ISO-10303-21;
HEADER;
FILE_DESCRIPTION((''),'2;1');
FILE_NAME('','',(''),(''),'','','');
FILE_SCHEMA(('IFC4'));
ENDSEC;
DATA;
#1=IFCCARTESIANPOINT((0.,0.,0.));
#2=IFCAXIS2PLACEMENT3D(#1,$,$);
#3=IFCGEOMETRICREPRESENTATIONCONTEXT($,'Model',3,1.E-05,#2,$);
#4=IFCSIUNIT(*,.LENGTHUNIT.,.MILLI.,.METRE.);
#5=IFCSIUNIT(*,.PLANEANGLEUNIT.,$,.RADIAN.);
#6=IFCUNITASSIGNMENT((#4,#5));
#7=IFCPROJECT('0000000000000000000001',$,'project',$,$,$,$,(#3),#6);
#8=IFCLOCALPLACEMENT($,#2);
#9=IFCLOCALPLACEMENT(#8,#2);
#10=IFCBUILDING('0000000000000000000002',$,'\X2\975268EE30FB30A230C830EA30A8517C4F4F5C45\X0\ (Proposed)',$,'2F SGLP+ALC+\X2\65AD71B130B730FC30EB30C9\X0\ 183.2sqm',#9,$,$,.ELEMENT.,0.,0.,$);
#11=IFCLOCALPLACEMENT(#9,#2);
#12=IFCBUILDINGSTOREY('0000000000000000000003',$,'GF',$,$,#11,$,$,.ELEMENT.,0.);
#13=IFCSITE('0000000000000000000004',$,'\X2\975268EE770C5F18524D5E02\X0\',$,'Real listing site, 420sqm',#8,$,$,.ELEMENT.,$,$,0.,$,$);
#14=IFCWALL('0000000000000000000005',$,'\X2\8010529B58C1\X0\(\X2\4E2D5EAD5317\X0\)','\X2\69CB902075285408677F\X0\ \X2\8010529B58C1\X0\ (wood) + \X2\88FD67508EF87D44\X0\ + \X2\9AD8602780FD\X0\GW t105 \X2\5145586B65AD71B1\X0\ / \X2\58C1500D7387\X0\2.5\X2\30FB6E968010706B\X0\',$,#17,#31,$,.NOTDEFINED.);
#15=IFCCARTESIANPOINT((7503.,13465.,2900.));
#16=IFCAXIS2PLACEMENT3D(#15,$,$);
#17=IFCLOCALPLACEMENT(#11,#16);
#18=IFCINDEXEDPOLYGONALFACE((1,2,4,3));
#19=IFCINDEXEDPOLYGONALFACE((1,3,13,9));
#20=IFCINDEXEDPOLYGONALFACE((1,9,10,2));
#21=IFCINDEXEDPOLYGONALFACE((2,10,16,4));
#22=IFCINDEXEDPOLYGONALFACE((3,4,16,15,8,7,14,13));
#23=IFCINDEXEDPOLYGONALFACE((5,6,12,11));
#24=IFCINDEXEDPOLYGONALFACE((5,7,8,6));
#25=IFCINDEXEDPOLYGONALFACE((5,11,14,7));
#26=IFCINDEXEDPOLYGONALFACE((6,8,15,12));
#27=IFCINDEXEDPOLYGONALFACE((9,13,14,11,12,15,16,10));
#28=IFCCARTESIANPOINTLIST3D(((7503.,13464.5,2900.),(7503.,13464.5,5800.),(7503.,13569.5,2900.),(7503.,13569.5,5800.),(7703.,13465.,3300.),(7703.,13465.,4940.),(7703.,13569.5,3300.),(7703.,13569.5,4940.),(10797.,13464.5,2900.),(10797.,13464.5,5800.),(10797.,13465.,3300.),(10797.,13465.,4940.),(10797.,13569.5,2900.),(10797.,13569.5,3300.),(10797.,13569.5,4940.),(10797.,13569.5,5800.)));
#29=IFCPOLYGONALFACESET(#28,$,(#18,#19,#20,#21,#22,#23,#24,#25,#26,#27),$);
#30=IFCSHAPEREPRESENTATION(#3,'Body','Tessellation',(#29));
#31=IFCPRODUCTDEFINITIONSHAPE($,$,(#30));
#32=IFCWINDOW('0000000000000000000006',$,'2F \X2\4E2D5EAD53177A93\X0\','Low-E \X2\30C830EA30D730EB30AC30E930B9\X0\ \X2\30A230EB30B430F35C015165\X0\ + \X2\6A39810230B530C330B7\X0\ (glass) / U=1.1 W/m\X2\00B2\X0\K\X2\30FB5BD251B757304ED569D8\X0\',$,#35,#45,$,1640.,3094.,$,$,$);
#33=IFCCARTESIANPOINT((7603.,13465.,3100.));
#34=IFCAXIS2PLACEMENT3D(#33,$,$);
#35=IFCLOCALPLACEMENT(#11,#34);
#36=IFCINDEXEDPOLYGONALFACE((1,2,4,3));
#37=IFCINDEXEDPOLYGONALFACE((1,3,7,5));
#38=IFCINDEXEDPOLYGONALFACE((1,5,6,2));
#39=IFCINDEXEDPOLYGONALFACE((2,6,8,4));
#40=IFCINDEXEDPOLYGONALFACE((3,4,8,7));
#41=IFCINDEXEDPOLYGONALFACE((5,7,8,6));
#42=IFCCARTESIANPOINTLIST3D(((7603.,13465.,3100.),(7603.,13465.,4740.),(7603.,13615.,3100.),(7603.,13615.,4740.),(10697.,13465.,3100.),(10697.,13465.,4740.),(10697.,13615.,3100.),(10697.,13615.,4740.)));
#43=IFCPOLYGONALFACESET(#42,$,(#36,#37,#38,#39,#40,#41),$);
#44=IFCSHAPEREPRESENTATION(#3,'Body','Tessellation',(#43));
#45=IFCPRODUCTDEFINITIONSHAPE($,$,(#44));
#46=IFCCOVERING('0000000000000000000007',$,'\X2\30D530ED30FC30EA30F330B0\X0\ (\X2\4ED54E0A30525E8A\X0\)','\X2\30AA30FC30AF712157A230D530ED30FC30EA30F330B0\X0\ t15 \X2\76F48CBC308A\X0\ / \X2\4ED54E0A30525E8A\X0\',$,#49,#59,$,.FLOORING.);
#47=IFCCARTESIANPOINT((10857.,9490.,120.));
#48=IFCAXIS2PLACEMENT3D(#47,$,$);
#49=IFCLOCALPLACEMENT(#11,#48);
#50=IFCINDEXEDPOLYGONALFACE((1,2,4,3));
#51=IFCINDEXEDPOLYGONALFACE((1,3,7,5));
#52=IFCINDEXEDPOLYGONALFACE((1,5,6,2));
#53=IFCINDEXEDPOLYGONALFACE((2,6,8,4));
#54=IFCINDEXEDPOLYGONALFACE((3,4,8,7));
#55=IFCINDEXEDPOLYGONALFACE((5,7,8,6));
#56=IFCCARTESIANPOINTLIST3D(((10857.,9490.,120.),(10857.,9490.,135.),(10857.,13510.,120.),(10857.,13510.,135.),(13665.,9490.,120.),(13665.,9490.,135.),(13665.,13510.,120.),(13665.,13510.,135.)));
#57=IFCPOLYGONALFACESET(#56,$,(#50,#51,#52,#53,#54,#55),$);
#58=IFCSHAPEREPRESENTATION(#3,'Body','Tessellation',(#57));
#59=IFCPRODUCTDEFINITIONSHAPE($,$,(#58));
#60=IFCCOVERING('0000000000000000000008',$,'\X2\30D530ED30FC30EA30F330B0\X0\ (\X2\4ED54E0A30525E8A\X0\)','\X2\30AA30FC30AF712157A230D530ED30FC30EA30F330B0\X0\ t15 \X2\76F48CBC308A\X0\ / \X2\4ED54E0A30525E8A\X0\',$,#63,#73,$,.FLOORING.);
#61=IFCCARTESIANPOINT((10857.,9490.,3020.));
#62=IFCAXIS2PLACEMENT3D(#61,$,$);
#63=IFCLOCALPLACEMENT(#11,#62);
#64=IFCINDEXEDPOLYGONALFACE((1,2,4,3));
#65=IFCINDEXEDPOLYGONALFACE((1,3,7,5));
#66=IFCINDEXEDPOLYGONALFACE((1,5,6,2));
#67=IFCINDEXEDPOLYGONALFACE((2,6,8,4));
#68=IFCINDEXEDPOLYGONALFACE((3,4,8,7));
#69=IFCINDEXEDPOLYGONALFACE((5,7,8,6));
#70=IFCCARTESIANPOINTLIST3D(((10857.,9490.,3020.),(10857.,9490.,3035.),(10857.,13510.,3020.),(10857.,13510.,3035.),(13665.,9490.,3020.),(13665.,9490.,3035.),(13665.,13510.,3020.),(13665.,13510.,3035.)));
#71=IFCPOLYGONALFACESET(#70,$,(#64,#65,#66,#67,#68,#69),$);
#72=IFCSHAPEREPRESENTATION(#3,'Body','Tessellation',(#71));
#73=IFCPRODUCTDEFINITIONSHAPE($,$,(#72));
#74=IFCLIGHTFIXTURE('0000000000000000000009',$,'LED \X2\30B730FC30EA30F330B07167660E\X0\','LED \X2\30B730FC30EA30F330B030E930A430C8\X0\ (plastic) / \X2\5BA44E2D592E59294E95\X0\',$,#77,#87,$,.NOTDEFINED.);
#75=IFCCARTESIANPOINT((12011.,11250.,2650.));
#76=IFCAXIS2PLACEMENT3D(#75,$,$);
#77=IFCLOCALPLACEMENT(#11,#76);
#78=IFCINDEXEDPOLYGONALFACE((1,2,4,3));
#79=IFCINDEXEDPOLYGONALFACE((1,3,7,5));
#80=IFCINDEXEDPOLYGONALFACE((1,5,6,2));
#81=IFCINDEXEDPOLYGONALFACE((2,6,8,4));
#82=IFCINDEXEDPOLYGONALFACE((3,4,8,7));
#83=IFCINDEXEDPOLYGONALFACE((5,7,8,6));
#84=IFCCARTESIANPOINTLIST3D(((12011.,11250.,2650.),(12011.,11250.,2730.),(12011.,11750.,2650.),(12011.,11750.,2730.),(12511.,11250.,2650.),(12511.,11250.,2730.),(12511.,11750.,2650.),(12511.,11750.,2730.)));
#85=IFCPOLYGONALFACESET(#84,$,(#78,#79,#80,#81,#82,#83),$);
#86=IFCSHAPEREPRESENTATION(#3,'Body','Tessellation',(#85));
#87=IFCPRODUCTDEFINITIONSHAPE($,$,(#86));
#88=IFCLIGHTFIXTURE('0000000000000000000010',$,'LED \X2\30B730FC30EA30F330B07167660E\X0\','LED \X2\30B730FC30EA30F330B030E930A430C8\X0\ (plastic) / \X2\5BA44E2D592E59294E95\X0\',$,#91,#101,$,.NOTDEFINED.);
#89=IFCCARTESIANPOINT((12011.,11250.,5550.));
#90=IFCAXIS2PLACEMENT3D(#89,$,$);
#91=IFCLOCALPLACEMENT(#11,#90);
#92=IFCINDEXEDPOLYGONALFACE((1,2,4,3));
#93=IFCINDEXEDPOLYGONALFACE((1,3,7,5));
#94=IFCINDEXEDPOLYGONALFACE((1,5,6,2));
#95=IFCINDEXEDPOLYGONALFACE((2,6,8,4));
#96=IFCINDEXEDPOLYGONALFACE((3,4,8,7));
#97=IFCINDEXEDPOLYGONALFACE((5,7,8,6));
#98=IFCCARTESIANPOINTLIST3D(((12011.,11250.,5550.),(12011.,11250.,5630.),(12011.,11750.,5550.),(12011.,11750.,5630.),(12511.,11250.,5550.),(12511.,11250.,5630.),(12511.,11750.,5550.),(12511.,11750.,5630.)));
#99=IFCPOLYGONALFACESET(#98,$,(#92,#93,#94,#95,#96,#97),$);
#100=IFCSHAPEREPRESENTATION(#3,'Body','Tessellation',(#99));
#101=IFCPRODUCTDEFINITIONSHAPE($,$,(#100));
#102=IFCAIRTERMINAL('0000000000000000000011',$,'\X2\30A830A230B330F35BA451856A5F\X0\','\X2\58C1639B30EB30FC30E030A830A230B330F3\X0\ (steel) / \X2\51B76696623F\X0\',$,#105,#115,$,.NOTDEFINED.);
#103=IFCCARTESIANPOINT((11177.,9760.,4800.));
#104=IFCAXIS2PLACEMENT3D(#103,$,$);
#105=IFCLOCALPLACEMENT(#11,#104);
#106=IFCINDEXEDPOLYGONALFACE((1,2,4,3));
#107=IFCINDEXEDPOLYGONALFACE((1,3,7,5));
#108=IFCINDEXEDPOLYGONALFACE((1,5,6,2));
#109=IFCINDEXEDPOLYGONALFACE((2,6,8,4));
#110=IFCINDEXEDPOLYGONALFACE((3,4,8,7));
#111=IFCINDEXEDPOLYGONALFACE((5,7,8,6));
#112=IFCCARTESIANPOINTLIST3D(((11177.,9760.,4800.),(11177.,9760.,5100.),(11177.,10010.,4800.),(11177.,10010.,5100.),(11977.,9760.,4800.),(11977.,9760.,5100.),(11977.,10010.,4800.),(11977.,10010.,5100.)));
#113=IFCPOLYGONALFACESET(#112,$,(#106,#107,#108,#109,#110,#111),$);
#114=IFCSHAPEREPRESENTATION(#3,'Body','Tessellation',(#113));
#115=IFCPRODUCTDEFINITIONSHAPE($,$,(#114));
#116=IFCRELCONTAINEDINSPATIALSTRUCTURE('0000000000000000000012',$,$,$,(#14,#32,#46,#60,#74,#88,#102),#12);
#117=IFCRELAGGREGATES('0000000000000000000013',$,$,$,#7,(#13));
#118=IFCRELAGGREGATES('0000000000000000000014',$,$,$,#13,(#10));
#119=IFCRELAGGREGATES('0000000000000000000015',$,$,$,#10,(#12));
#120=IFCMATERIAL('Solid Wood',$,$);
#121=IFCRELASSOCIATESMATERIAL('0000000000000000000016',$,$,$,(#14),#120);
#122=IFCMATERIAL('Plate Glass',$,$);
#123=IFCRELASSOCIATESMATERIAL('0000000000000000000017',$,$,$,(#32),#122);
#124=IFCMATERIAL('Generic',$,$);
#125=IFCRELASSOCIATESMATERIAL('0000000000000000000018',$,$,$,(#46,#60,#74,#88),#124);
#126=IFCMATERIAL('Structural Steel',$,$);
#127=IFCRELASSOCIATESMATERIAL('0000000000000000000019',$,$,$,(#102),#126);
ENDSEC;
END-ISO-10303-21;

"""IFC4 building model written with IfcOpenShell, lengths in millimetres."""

from ifc_helpers import new_model, si_unit, frame, frame_2d, origin, place, context, project, spatial, rectangle, extrude, material, element, fill, save


model = new_model("IFC4")

# Units and contexts
model_context = context("Model", 3, precision=1e-05, world=origin())
ifc_project = project(units=[si_unit("LENGTHUNIT", "METRE", prefix="MILLI"), si_unit("PLANEANGLEUNIT", "RADIAN")], contexts=[model_context])

# Site, building, storey
site_placement = place(None, origin())
site = spatial("IfcSite", under=ifc_project, at=site_placement, Name="青森県弘前市", ObjectType="Real listing site, 420sqm", CompositionType="ELEMENT", RefElevation=0.0)
building_placement = place(site_placement, origin())
building = spatial("IfcBuilding", under=site, at=building_placement, Name="青森・アトリエ兼住居 (Proposed)", ObjectType="2F SGLP+ALC+断熱シールド 183.2sqm", CompositionType="ELEMENT", ElevationOfRefHeight=0.0, ElevationOfTerrain=0.0)
storey_placement = place(building_placement, origin())
storey = spatial("IfcBuildingStorey", under=building, at=storey_placement, Name="GF", CompositionType="ELEMENT", Elevation=0.0)

# Shared definitions
ifc_material_1 = material(Name="Solid Wood")

# Wall, opening, window
ifc_material_2 = material(Name="Plate Glass")
wall_1_placement = place(storey_placement, frame((7503.0, 13465.0, 2900.0)))
wall_1 = element("IfcWall", 1, at=wall_1_placement, inside=storey, material=ifc_material_1, Name="耐力壁(中庭北)", Description="構造用合板 耐力壁 (wood) + 製材軸組 + 高性能GW t105 充填断熱 / 壁倍率2.5・準耐火", PredefinedType="NOTDEFINED", context=model_context, shape_type="SweptSolid", body=[
    extrude(rectangle(XDim=3294.0, YDim=105.0, at=frame_2d((1647.0, 52.0))), frame((7503.0, 13465.0, 2900.0)), (0.0, 0.0, 1.0), 2900.0),
])
opening_1_placement = place(storey_placement, frame((7603.0, 13465.0, 3100.0)))
opening_1 = element("IfcOpeningElement", 2, at=opening_1_placement, cuts=wall_1, PredefinedType="NOTDEFINED", context=model_context, shape_type="SweptSolid", body=[
    extrude(rectangle(XDim=3094.0, YDim=150.0, at=frame_2d((1547.0, 75.0))), frame((7603.0, 13465.0, 3100.0)), (0.0, 0.0, 1.0), 1640.0),
])
window_1_placement = place(storey_placement, frame((7603.0, 13465.0, 3100.0)))
window_1 = element("IfcWindow", 3, at=window_1_placement, inside=storey, material=ifc_material_2, Name="2F 中庭北窓", Description="Low-E トリプルガラス アルゴン封入 + 樹脂サッシ (glass) / U=1.1 W/m²K・寒冷地仕様", OverallHeight=1640.0, OverallWidth=3094.0, context=model_context, shape_type="SweptSolid", body=[
    extrude(rectangle(XDim=3094.0, YDim=150.0, at=frame_2d((1547.0, 75.0))), frame((7603.0, 13465.0, 3100.0)), (0.0, 0.0, 1.0), 1640.0),
])
fill(opening_1, window_1)

# Coverings
ifc_material_3 = material(Name="Generic")
covering_1_placement = place(storey_placement, frame((10857.0, 9490.0, 120.0)))
element("IfcCovering", 4, at=covering_1_placement, inside=storey, material=ifc_material_3, Name="フローリング (仕上げ床)", Description="オーク無垢フローリング t15 直貼り / 仕上げ床", PredefinedType="FLOORING", context=model_context, shape_type="SweptSolid", body=[
    extrude(rectangle(XDim=2808.0, YDim=4020.0, at=frame_2d((1404.0, 2010.0))), frame((10857.0, 9490.0, 120.0)), (0.0, 0.0, 1.0), 15.0),
])
covering_2_placement = place(storey_placement, frame((10857.0, 9490.0, 3020.0)))
element("IfcCovering", 5, at=covering_2_placement, inside=storey, material=ifc_material_3, Name="フローリング (仕上げ床)", Description="オーク無垢フローリング t15 直貼り / 仕上げ床", PredefinedType="FLOORING", context=model_context, shape_type="SweptSolid", body=[
    extrude(rectangle(XDim=2808.0, YDim=4020.0, at=frame_2d((1404.0, 2010.0))), frame((10857.0, 9490.0, 3020.0)), (0.0, 0.0, 1.0), 15.0),
])

# Light fixtures
light_fixture_1_placement = place(storey_placement, frame((12011.0, 11250.0, 2650.0)))
element("IfcLightFixture", 6, at=light_fixture_1_placement, inside=storey, material=ifc_material_3, Name="LED シーリング照明", Description="LED シーリングライト (plastic) / 室中央天井", PredefinedType="NOTDEFINED", context=model_context, shape_type="SweptSolid", body=[
    extrude(rectangle(XDim=500.0, YDim=500.0, at=frame_2d((250.0, 250.0))), frame((12011.0, 11250.0, 2650.0)), (0.0, 0.0, 1.0), 80.0),
])
light_fixture_2_placement = place(storey_placement, frame((12011.0, 11250.0, 5550.0)))
element("IfcLightFixture", 7, at=light_fixture_2_placement, inside=storey, material=ifc_material_3, Name="LED シーリング照明", Description="LED シーリングライト (plastic) / 室中央天井", PredefinedType="NOTDEFINED", context=model_context, shape_type="SweptSolid", body=[
    extrude(rectangle(XDim=500.0, YDim=500.0, at=frame_2d((250.0, 250.0))), frame((12011.0, 11250.0, 5550.0)), (0.0, 0.0, 1.0), 80.0),
])

# Air terminal
ifc_material_4 = material(Name="Structural Steel")
air_terminal_placement = place(storey_placement, frame((11177.0, 9760.0, 4800.0)))
element("IfcAirTerminal", 8, at=air_terminal_placement, inside=storey, material=ifc_material_4, Name="エアコン室内機", Description="壁掛ルームエアコン (steel) / 冷暖房", PredefinedType="NOTDEFINED", context=model_context, shape_type="SweptSolid", body=[
    extrude(rectangle(XDim=800.0, YDim=250.0, at=frame_2d((400.0, 125.0))), frame((11177.0, 9760.0, 4800.0)), (0.0, 0.0, 1.0), 300.0),
])

save(model, "model.ifc")
